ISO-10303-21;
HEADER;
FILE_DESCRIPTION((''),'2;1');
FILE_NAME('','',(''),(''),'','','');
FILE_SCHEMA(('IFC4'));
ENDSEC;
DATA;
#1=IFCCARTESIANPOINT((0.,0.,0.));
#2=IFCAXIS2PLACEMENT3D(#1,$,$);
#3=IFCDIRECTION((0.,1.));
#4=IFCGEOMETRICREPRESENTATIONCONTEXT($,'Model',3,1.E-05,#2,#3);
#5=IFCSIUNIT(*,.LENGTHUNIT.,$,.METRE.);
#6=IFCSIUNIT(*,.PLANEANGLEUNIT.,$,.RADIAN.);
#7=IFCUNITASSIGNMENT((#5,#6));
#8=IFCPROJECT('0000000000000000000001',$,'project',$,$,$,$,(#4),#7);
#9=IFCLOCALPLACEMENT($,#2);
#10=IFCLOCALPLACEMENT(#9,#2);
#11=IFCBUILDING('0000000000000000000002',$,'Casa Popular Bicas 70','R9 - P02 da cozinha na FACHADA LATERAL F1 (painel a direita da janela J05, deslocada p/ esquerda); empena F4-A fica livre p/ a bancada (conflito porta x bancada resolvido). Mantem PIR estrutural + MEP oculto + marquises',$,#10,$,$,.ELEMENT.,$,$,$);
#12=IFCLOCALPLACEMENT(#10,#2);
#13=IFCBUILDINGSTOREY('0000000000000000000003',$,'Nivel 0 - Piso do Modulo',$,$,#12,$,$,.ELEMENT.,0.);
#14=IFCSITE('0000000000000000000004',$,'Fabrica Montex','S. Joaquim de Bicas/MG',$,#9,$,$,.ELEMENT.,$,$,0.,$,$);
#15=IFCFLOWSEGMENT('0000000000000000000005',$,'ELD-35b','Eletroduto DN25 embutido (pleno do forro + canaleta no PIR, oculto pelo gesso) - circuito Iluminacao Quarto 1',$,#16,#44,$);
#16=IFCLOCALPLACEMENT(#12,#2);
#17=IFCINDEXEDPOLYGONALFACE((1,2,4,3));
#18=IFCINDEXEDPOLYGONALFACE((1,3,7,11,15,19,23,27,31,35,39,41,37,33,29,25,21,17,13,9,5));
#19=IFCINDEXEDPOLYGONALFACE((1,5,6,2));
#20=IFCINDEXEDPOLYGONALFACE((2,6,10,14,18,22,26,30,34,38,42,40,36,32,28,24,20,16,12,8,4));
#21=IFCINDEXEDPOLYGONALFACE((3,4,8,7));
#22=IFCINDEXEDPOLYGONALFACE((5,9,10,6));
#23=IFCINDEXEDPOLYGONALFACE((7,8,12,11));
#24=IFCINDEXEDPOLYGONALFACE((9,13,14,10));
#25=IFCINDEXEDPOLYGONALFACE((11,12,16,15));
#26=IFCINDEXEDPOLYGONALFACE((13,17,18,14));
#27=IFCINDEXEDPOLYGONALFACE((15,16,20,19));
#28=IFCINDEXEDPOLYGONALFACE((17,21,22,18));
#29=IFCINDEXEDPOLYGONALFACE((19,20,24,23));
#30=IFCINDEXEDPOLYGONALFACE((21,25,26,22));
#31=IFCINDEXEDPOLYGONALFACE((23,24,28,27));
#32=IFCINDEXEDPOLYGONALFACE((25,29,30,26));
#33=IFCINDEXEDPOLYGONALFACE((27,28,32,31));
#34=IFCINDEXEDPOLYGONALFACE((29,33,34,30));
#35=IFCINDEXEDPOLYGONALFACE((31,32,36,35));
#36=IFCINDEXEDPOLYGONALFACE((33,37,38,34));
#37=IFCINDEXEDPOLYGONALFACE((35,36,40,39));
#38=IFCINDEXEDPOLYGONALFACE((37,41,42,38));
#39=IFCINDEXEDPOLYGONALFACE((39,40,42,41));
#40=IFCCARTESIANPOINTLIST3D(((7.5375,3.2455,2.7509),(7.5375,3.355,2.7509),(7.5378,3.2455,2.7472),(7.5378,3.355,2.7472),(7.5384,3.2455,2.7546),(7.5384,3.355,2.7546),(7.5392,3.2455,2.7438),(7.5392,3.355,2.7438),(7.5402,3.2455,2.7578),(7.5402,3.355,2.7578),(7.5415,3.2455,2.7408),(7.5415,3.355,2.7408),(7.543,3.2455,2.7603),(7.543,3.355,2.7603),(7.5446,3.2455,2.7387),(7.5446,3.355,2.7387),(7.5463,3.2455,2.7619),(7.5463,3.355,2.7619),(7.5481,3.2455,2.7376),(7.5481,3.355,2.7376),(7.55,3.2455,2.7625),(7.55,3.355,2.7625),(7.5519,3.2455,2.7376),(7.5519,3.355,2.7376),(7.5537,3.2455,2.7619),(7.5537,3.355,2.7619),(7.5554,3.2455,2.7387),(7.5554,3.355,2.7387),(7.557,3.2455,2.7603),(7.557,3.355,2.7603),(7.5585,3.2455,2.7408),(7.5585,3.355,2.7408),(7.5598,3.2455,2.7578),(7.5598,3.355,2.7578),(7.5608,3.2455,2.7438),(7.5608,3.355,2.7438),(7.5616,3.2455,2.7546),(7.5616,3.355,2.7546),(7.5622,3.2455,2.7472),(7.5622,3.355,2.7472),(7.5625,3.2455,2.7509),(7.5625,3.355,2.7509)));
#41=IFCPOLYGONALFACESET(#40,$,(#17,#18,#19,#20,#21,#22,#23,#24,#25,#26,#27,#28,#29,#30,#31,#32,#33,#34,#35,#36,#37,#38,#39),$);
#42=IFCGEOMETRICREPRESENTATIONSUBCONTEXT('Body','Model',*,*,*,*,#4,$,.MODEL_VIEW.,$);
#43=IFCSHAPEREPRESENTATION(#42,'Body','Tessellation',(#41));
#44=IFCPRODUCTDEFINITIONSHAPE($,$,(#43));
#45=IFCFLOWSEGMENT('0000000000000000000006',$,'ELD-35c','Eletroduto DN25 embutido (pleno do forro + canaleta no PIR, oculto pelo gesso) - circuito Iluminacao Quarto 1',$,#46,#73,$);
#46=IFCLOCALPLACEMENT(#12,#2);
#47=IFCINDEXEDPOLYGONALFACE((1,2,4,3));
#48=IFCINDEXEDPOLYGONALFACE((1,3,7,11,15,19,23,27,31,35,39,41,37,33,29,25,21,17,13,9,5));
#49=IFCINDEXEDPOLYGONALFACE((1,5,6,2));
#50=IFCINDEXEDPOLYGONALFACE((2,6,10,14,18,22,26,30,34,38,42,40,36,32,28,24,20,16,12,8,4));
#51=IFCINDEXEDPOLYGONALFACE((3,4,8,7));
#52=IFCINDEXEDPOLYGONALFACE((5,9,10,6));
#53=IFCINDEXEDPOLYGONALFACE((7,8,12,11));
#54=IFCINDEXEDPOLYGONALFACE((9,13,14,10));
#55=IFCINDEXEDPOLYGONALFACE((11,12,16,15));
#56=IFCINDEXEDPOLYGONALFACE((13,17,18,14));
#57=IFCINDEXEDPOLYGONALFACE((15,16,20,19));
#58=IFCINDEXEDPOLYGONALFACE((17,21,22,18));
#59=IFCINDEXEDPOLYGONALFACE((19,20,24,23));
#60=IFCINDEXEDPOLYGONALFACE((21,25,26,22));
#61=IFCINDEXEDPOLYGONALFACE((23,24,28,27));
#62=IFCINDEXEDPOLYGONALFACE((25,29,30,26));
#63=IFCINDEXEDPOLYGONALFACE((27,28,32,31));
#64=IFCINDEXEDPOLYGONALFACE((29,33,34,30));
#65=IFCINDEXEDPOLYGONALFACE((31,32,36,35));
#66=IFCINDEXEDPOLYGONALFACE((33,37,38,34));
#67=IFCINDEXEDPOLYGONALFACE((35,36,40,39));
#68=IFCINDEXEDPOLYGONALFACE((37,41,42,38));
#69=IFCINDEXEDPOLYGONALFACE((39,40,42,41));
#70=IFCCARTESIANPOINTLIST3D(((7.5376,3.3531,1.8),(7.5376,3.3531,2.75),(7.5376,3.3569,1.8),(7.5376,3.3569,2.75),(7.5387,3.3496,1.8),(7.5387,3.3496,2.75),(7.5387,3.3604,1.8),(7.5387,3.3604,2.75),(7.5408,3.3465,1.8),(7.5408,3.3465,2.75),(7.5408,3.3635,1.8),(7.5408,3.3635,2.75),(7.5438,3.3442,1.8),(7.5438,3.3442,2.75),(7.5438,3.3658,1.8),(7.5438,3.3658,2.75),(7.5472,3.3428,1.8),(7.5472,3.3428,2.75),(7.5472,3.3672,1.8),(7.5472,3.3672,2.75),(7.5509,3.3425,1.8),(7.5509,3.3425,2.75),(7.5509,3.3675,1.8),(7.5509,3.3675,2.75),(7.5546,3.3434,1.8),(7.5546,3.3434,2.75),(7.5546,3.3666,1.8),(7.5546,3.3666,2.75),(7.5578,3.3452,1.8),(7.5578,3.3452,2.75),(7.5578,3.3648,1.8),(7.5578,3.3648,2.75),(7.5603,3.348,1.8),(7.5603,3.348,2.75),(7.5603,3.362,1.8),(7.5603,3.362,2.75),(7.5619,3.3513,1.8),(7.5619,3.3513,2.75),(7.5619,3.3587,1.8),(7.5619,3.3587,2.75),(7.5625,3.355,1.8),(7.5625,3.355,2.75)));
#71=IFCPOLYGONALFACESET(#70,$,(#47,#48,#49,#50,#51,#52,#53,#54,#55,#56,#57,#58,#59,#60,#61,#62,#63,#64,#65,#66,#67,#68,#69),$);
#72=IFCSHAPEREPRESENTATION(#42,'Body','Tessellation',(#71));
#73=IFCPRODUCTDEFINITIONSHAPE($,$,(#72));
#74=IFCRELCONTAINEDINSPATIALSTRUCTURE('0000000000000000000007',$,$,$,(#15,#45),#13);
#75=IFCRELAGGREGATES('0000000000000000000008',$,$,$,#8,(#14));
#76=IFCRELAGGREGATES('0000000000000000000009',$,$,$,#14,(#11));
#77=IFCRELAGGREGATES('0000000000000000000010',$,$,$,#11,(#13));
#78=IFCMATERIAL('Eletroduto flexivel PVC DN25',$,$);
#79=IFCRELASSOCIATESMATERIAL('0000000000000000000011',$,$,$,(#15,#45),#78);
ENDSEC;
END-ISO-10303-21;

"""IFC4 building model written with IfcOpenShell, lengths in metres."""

from ifc_helpers import new_model, si_unit, direction, frame, origin, origin_2d, place, context, subcontext, project, spatial, circle, extrude, material, element, save


model = new_model("IFC4")

# Units and contexts
model_context = context("Model", 3, precision=1e-05, world=origin(), true_north=direction((0.0, 1.0)))
body_context = subcontext(model_context, "Body", "Model", "MODEL_VIEW")
ifc_project = project(units=[si_unit("LENGTHUNIT", "METRE"), si_unit("PLANEANGLEUNIT", "RADIAN")], contexts=[model_context])

# Site, building, storey
site_placement = place(None, origin())
site = spatial("IfcSite", under=ifc_project, at=site_placement, Name="Fabrica Montex", Description="S. Joaquim de Bicas/MG", CompositionType="ELEMENT", RefElevation=0.0)
building_placement = place(site_placement, origin())
building = spatial("IfcBuilding", under=site, at=building_placement, Name="Casa Popular Bicas 70", Description="R9 - P02 da cozinha na FACHADA LATERAL F1 (painel a direita da janela J05, deslocada p/ esquerda); empena F4-A fica livre p/ a bancada (conflito porta x bancada resolvido). Mantem PIR estrutural + MEP oculto + marquises", CompositionType="ELEMENT")
storey_placement = place(building_placement, origin())
storey = spatial("IfcBuildingStorey", under=building, at=storey_placement, Name="Nivel 0 - Piso do Modulo", CompositionType="ELEMENT", Elevation=0.0)

# Shared definitions
ifc_material_1 = material(Name="Eletroduto flexivel PVC DN25")

# Flow segments
flow_segment_1_placement = place(storey_placement, frame((7.55, 3.2455, 2.75), z_axis=(0.0, 1.0, 0.0), x_axis=(0.0, 0.0, 1.0)))
element("IfcFlowSegment", 1, at=flow_segment_1_placement, inside=storey, material=ifc_material_1, Name="ELD-35b", Description="Eletroduto DN25 embutido (pleno do forro + canaleta no PIR, oculto pelo gesso) - circuito Iluminacao Quarto 1", context=body_context, shape_type="SweptSolid", body=[
    extrude(circle(Radius=0.0125, at=origin_2d()), origin(), (0.0, 0.0, 1.0), 0.1095),
])
flow_segment_2_placement = place(storey_placement, frame((7.55, 3.355, 2.75), z_axis=(0.0, 0.0, -1.0), x_axis=(1.0, 0.0, 0.0)))
element("IfcFlowSegment", 2, at=flow_segment_2_placement, inside=storey, material=ifc_material_1, Name="ELD-35c", Description="Eletroduto DN25 embutido (pleno do forro + canaleta no PIR, oculto pelo gesso) - circuito Iluminacao Quarto 1", context=body_context, shape_type="SweptSolid", body=[
    extrude(circle(Radius=0.0125, at=origin_2d()), origin(), (0.0, 0.0, 1.0), 0.95),
])

save(model, "model.ifc")
